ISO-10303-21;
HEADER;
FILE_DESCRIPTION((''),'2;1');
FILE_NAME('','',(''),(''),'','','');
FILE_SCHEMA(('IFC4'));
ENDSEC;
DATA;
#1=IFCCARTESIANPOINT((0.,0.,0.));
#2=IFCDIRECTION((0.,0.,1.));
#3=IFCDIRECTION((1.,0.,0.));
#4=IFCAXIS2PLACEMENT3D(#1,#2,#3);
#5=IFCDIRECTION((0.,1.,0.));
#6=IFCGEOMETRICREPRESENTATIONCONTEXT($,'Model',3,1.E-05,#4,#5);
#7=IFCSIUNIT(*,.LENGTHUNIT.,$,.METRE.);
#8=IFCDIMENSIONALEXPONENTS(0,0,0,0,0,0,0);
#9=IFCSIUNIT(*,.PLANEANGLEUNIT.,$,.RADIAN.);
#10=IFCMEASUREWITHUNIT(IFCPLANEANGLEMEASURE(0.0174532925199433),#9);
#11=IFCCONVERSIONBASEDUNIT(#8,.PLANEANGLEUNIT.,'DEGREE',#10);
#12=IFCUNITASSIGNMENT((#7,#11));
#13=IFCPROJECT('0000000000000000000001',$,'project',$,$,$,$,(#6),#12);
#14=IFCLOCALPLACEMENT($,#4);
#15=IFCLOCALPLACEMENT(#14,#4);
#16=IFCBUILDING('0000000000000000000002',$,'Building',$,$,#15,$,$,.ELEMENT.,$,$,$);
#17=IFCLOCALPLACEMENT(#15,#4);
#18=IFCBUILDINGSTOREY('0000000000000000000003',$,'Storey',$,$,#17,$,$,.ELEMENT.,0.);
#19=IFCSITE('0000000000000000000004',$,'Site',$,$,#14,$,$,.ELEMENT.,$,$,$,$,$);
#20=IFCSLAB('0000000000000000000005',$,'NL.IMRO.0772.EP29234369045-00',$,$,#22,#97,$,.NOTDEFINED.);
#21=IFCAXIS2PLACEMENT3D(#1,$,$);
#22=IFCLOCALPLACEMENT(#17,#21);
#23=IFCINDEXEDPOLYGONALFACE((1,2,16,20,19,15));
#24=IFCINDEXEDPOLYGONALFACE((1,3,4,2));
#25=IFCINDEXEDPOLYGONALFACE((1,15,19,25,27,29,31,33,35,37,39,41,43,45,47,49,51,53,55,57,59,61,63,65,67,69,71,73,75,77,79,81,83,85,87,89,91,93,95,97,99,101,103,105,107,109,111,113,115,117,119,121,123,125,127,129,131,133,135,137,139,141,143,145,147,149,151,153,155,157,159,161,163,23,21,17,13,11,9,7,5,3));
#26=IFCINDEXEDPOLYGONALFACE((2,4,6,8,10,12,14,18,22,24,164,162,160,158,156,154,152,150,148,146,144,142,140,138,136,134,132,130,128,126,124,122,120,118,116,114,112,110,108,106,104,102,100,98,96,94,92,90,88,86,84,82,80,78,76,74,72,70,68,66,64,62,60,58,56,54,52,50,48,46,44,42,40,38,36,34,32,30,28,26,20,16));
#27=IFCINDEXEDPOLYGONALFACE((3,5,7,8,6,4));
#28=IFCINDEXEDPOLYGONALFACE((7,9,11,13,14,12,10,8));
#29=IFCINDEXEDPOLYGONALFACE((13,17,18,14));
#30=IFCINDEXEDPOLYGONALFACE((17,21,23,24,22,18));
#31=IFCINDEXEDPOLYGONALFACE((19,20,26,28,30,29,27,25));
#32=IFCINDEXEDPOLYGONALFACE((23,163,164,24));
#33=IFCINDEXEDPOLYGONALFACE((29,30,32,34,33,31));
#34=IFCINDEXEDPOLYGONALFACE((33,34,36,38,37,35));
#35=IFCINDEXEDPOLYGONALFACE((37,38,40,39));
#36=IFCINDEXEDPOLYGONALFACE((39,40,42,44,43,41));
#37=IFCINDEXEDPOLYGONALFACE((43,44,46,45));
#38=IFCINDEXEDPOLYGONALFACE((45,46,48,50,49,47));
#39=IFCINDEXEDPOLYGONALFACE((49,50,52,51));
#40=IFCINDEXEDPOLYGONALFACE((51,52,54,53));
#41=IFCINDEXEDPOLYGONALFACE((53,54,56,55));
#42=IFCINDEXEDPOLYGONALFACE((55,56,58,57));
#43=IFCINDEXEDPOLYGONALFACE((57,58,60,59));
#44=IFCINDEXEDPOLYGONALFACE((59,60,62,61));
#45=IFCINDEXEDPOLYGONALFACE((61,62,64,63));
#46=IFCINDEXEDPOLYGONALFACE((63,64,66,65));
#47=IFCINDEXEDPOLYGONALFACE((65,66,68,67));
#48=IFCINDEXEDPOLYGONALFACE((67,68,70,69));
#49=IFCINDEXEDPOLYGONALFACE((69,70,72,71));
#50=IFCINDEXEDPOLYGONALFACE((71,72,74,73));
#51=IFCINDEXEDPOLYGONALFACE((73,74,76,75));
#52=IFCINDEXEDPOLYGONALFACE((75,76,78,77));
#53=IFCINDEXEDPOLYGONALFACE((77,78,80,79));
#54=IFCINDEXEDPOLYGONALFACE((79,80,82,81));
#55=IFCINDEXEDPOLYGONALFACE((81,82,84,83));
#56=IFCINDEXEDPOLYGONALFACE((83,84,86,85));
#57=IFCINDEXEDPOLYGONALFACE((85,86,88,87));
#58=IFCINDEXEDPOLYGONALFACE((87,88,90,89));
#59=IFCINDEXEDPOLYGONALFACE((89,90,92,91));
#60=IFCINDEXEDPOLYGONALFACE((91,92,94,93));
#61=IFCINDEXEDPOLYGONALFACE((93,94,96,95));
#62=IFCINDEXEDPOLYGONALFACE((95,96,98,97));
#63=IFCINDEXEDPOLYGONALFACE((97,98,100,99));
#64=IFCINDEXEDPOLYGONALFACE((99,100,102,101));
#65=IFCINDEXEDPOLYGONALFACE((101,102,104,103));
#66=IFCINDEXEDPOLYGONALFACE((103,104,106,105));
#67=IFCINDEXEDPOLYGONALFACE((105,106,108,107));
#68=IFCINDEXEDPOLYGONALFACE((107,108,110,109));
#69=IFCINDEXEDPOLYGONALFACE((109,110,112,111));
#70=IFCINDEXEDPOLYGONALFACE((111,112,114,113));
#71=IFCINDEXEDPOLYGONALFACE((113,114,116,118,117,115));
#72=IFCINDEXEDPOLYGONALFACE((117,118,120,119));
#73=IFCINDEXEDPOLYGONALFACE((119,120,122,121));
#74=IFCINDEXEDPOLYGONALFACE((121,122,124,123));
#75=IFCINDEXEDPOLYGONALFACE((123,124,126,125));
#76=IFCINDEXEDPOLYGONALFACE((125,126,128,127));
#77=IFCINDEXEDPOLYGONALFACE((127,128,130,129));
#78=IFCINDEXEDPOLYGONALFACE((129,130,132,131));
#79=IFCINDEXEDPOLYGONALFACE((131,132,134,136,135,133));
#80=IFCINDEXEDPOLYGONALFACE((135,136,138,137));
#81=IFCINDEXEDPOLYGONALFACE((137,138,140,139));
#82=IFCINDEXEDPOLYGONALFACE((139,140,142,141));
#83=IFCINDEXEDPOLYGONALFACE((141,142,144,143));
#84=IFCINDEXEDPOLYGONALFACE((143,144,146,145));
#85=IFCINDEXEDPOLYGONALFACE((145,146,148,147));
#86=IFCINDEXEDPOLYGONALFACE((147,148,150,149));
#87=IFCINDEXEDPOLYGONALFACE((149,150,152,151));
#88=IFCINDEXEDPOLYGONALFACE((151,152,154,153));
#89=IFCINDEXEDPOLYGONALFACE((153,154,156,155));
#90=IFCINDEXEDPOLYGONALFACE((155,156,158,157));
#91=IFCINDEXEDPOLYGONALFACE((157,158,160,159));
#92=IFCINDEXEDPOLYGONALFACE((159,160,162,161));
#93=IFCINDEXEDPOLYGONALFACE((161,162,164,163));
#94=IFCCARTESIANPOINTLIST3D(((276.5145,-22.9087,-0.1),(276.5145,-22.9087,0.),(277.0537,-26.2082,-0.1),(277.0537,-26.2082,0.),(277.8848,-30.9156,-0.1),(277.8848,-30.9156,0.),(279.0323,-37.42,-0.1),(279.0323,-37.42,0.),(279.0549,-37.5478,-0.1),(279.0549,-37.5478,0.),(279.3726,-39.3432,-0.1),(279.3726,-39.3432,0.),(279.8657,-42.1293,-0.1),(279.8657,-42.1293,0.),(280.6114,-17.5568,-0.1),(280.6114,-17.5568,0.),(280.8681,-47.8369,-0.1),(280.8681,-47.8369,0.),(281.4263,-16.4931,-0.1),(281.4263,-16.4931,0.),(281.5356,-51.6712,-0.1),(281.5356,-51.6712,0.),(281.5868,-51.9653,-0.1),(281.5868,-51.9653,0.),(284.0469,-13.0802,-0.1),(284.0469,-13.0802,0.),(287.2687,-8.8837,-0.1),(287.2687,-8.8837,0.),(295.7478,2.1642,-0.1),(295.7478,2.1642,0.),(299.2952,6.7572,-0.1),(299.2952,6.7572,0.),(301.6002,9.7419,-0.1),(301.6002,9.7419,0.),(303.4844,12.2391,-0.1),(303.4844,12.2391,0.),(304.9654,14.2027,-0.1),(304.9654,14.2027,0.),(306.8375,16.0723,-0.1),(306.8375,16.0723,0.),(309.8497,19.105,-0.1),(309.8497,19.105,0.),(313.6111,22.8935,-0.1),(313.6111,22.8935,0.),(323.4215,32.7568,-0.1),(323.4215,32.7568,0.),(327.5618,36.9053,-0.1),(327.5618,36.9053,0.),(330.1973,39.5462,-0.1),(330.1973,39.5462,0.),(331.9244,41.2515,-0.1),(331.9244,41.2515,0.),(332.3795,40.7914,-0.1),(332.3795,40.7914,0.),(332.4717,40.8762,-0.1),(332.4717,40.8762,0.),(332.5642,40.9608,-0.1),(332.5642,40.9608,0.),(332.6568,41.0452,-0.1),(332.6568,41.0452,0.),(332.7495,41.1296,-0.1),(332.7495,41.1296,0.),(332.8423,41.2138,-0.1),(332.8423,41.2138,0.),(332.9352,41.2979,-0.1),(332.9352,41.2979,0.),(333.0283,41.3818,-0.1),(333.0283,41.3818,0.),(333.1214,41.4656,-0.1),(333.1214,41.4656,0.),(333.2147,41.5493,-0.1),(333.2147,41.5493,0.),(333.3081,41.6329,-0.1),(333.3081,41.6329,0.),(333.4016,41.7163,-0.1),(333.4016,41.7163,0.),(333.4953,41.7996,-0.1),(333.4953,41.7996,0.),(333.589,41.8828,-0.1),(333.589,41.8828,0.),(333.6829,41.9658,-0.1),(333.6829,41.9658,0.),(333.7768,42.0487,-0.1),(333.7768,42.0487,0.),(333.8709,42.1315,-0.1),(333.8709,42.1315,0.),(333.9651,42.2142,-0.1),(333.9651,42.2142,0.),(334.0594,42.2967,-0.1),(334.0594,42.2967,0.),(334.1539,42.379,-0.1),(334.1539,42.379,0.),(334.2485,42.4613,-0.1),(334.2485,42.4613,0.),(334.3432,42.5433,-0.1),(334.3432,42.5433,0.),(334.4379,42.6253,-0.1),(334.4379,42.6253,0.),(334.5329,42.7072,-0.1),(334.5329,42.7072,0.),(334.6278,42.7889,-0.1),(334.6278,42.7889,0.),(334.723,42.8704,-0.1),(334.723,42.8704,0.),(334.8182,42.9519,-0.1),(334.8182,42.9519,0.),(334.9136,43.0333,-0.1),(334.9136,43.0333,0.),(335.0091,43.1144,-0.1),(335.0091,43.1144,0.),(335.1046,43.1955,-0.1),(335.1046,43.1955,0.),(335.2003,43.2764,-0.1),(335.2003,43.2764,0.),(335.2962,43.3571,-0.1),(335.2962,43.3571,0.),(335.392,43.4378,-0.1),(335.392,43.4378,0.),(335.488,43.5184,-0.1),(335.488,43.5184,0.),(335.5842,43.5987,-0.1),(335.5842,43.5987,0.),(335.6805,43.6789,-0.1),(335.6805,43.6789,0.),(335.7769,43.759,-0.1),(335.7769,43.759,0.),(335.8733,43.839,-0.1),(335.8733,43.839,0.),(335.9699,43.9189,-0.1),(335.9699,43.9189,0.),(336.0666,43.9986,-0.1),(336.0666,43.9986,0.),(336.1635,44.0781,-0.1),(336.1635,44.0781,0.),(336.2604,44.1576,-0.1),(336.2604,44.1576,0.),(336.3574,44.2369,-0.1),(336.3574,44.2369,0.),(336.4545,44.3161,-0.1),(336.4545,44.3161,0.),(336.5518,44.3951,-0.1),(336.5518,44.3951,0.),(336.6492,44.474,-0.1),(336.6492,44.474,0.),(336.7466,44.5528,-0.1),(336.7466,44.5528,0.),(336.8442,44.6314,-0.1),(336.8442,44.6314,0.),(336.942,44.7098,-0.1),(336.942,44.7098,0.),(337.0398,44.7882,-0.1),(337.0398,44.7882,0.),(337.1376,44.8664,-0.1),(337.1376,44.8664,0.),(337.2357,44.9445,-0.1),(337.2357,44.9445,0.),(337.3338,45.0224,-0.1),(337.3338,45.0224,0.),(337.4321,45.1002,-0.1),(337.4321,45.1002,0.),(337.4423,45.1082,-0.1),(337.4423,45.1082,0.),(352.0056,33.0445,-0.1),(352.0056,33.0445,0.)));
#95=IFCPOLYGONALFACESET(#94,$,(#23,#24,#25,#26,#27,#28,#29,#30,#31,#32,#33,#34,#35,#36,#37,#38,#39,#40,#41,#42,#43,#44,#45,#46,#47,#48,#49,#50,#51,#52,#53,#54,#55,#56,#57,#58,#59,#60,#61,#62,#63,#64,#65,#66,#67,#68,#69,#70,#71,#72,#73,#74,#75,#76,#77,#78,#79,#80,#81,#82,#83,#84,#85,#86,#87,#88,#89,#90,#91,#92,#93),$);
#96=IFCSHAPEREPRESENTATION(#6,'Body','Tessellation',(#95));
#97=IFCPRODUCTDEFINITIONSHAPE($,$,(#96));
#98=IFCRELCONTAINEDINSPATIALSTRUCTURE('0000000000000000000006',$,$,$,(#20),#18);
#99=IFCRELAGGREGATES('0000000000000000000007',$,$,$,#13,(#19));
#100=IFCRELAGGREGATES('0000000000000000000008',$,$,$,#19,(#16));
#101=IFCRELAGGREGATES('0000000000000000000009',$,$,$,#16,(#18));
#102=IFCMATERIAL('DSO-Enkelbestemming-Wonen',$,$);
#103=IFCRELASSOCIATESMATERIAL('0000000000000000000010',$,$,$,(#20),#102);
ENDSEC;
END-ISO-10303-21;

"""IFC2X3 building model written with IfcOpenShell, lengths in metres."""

from ifc_helpers import new_model, entity, si_unit, converted_unit, direction, frame, origin_with_axes, place, context, project, spatial, polyline, outline, extrude, material, element, save


model = new_model("IFC2X3")

# Units and contexts
model_context = context("Model", 3, precision=1e-05, world=origin_with_axes(), true_north=direction((0.0, 1.0, 0.0)))
ifc_project = project(units=[si_unit("LENGTHUNIT", "METRE"), converted_unit("PLANEANGLEUNIT", "DEGREE", entity("IfcPlaneAngleMeasure", 0.0174532925199433), si_unit("PLANEANGLEUNIT", "RADIAN"), dimensions=[0, 0, 0, 0, 0, 0, 0])], contexts=[model_context])

# Site, building, storey
site_placement = place(None, origin_with_axes())
site = spatial("IfcSite", under=ifc_project, at=site_placement, Name="Site", CompositionType="ELEMENT")
building_placement = place(site_placement, origin_with_axes())
building = spatial("IfcBuilding", under=site, at=building_placement, Name="Building", CompositionType="ELEMENT")
storey_placement = place(building_placement, origin_with_axes())
storey = spatial("IfcBuildingStorey", under=building, at=storey_placement, Name="Storey", CompositionType="ELEMENT", Elevation=0.0)

# Slab
ifc_material_1 = material(Name="DSO-Enkelbestemming-Wonen")
slab_1_placement = place(storey_placement, frame((0.0, 0.0, -0.1), z_axis=(0.0, 0.0, 1.0), x_axis=(1.0, 0.0, 0.0)))
element("IfcSlab", 1, at=slab_1_placement, inside=storey, material=ifc_material_1, Name="NL.IMRO.0772.EP29234369045-00", PredefinedType="NOTDEFINED", context=model_context, shape_type="SweptSolid", body=[
    extrude(outline(polyline([(281.5356, -51.6712), (280.8681, -47.8369), (279.8657, -42.1293), (279.3726, -39.3432), (279.0549, -37.5478), (279.0323, -37.42), (277.8848, -30.9156), (277.0537, -26.2082), (276.5145, -22.9087), (280.6114, -17.5568), (281.4263, -16.4931), (284.0469, -13.0802), (287.2687, -8.8837), (295.7478, 2.1642), (299.2952, 6.7572), (301.6002, 9.7419), (303.4844, 12.2391), (304.9654, 14.2027), (306.8375, 16.0723), (309.8497, 19.105), (313.6111, 22.8935), (323.4215, 32.7568), (327.5618, 36.9053), (330.1973, 39.5462), (331.9244, 41.2515), (332.3795, 40.7914), (332.4717, 40.8762), (332.5642, 40.9608), (332.6568, 41.0452), (332.7495, 41.1296), (332.8423, 41.2138), (332.9352, 41.2979), (333.0283, 41.3818), (333.1214, 41.4656), (333.2147, 41.5493), (333.3081, 41.6329), (333.4016, 41.7163), (333.4953, 41.7996), (333.589, 41.8828), (333.6829, 41.9658), (333.7768, 42.0487), (333.8709, 42.1315), (333.9651, 42.2142), (334.0594, 42.2967), (334.1539, 42.379), (334.2485, 42.4613), (334.3432, 42.5433), (334.4379, 42.6253), (334.5329, 42.7072), (334.6278, 42.7889), (334.723, 42.8704), (334.8182, 42.9519), (334.9136, 43.0333), (335.0091, 43.1144), (335.1046, 43.1955), (335.2003, 43.2764), (335.2962, 43.3571), (335.392, 43.4378), (335.488, 43.5184), (335.5842, 43.5987), (335.6805, 43.6789), (335.7769, 43.759), (335.8733, 43.839), (335.9699, 43.9189), (336.0666, 43.9986), (336.1635, 44.0781), (336.2604, 44.1576), (336.3574, 44.2369), (336.4545, 44.3161), (336.5518, 44.3951), (336.6492, 44.474), (336.7466, 44.5528), (336.8442, 44.6314), (336.942, 44.7098), (337.0398, 44.7882), (337.1376, 44.8664), (337.2357, 44.9445), (337.3338, 45.0224), (337.4321, 45.1002), (337.4423, 45.1082), (352.0056, 33.0445), (281.5868, -51.9653), (281.5356, -51.6712)])), origin_with_axes(), (0.0, 0.0, 1.0), 0.1),
])

save(model, "model.ifc")
